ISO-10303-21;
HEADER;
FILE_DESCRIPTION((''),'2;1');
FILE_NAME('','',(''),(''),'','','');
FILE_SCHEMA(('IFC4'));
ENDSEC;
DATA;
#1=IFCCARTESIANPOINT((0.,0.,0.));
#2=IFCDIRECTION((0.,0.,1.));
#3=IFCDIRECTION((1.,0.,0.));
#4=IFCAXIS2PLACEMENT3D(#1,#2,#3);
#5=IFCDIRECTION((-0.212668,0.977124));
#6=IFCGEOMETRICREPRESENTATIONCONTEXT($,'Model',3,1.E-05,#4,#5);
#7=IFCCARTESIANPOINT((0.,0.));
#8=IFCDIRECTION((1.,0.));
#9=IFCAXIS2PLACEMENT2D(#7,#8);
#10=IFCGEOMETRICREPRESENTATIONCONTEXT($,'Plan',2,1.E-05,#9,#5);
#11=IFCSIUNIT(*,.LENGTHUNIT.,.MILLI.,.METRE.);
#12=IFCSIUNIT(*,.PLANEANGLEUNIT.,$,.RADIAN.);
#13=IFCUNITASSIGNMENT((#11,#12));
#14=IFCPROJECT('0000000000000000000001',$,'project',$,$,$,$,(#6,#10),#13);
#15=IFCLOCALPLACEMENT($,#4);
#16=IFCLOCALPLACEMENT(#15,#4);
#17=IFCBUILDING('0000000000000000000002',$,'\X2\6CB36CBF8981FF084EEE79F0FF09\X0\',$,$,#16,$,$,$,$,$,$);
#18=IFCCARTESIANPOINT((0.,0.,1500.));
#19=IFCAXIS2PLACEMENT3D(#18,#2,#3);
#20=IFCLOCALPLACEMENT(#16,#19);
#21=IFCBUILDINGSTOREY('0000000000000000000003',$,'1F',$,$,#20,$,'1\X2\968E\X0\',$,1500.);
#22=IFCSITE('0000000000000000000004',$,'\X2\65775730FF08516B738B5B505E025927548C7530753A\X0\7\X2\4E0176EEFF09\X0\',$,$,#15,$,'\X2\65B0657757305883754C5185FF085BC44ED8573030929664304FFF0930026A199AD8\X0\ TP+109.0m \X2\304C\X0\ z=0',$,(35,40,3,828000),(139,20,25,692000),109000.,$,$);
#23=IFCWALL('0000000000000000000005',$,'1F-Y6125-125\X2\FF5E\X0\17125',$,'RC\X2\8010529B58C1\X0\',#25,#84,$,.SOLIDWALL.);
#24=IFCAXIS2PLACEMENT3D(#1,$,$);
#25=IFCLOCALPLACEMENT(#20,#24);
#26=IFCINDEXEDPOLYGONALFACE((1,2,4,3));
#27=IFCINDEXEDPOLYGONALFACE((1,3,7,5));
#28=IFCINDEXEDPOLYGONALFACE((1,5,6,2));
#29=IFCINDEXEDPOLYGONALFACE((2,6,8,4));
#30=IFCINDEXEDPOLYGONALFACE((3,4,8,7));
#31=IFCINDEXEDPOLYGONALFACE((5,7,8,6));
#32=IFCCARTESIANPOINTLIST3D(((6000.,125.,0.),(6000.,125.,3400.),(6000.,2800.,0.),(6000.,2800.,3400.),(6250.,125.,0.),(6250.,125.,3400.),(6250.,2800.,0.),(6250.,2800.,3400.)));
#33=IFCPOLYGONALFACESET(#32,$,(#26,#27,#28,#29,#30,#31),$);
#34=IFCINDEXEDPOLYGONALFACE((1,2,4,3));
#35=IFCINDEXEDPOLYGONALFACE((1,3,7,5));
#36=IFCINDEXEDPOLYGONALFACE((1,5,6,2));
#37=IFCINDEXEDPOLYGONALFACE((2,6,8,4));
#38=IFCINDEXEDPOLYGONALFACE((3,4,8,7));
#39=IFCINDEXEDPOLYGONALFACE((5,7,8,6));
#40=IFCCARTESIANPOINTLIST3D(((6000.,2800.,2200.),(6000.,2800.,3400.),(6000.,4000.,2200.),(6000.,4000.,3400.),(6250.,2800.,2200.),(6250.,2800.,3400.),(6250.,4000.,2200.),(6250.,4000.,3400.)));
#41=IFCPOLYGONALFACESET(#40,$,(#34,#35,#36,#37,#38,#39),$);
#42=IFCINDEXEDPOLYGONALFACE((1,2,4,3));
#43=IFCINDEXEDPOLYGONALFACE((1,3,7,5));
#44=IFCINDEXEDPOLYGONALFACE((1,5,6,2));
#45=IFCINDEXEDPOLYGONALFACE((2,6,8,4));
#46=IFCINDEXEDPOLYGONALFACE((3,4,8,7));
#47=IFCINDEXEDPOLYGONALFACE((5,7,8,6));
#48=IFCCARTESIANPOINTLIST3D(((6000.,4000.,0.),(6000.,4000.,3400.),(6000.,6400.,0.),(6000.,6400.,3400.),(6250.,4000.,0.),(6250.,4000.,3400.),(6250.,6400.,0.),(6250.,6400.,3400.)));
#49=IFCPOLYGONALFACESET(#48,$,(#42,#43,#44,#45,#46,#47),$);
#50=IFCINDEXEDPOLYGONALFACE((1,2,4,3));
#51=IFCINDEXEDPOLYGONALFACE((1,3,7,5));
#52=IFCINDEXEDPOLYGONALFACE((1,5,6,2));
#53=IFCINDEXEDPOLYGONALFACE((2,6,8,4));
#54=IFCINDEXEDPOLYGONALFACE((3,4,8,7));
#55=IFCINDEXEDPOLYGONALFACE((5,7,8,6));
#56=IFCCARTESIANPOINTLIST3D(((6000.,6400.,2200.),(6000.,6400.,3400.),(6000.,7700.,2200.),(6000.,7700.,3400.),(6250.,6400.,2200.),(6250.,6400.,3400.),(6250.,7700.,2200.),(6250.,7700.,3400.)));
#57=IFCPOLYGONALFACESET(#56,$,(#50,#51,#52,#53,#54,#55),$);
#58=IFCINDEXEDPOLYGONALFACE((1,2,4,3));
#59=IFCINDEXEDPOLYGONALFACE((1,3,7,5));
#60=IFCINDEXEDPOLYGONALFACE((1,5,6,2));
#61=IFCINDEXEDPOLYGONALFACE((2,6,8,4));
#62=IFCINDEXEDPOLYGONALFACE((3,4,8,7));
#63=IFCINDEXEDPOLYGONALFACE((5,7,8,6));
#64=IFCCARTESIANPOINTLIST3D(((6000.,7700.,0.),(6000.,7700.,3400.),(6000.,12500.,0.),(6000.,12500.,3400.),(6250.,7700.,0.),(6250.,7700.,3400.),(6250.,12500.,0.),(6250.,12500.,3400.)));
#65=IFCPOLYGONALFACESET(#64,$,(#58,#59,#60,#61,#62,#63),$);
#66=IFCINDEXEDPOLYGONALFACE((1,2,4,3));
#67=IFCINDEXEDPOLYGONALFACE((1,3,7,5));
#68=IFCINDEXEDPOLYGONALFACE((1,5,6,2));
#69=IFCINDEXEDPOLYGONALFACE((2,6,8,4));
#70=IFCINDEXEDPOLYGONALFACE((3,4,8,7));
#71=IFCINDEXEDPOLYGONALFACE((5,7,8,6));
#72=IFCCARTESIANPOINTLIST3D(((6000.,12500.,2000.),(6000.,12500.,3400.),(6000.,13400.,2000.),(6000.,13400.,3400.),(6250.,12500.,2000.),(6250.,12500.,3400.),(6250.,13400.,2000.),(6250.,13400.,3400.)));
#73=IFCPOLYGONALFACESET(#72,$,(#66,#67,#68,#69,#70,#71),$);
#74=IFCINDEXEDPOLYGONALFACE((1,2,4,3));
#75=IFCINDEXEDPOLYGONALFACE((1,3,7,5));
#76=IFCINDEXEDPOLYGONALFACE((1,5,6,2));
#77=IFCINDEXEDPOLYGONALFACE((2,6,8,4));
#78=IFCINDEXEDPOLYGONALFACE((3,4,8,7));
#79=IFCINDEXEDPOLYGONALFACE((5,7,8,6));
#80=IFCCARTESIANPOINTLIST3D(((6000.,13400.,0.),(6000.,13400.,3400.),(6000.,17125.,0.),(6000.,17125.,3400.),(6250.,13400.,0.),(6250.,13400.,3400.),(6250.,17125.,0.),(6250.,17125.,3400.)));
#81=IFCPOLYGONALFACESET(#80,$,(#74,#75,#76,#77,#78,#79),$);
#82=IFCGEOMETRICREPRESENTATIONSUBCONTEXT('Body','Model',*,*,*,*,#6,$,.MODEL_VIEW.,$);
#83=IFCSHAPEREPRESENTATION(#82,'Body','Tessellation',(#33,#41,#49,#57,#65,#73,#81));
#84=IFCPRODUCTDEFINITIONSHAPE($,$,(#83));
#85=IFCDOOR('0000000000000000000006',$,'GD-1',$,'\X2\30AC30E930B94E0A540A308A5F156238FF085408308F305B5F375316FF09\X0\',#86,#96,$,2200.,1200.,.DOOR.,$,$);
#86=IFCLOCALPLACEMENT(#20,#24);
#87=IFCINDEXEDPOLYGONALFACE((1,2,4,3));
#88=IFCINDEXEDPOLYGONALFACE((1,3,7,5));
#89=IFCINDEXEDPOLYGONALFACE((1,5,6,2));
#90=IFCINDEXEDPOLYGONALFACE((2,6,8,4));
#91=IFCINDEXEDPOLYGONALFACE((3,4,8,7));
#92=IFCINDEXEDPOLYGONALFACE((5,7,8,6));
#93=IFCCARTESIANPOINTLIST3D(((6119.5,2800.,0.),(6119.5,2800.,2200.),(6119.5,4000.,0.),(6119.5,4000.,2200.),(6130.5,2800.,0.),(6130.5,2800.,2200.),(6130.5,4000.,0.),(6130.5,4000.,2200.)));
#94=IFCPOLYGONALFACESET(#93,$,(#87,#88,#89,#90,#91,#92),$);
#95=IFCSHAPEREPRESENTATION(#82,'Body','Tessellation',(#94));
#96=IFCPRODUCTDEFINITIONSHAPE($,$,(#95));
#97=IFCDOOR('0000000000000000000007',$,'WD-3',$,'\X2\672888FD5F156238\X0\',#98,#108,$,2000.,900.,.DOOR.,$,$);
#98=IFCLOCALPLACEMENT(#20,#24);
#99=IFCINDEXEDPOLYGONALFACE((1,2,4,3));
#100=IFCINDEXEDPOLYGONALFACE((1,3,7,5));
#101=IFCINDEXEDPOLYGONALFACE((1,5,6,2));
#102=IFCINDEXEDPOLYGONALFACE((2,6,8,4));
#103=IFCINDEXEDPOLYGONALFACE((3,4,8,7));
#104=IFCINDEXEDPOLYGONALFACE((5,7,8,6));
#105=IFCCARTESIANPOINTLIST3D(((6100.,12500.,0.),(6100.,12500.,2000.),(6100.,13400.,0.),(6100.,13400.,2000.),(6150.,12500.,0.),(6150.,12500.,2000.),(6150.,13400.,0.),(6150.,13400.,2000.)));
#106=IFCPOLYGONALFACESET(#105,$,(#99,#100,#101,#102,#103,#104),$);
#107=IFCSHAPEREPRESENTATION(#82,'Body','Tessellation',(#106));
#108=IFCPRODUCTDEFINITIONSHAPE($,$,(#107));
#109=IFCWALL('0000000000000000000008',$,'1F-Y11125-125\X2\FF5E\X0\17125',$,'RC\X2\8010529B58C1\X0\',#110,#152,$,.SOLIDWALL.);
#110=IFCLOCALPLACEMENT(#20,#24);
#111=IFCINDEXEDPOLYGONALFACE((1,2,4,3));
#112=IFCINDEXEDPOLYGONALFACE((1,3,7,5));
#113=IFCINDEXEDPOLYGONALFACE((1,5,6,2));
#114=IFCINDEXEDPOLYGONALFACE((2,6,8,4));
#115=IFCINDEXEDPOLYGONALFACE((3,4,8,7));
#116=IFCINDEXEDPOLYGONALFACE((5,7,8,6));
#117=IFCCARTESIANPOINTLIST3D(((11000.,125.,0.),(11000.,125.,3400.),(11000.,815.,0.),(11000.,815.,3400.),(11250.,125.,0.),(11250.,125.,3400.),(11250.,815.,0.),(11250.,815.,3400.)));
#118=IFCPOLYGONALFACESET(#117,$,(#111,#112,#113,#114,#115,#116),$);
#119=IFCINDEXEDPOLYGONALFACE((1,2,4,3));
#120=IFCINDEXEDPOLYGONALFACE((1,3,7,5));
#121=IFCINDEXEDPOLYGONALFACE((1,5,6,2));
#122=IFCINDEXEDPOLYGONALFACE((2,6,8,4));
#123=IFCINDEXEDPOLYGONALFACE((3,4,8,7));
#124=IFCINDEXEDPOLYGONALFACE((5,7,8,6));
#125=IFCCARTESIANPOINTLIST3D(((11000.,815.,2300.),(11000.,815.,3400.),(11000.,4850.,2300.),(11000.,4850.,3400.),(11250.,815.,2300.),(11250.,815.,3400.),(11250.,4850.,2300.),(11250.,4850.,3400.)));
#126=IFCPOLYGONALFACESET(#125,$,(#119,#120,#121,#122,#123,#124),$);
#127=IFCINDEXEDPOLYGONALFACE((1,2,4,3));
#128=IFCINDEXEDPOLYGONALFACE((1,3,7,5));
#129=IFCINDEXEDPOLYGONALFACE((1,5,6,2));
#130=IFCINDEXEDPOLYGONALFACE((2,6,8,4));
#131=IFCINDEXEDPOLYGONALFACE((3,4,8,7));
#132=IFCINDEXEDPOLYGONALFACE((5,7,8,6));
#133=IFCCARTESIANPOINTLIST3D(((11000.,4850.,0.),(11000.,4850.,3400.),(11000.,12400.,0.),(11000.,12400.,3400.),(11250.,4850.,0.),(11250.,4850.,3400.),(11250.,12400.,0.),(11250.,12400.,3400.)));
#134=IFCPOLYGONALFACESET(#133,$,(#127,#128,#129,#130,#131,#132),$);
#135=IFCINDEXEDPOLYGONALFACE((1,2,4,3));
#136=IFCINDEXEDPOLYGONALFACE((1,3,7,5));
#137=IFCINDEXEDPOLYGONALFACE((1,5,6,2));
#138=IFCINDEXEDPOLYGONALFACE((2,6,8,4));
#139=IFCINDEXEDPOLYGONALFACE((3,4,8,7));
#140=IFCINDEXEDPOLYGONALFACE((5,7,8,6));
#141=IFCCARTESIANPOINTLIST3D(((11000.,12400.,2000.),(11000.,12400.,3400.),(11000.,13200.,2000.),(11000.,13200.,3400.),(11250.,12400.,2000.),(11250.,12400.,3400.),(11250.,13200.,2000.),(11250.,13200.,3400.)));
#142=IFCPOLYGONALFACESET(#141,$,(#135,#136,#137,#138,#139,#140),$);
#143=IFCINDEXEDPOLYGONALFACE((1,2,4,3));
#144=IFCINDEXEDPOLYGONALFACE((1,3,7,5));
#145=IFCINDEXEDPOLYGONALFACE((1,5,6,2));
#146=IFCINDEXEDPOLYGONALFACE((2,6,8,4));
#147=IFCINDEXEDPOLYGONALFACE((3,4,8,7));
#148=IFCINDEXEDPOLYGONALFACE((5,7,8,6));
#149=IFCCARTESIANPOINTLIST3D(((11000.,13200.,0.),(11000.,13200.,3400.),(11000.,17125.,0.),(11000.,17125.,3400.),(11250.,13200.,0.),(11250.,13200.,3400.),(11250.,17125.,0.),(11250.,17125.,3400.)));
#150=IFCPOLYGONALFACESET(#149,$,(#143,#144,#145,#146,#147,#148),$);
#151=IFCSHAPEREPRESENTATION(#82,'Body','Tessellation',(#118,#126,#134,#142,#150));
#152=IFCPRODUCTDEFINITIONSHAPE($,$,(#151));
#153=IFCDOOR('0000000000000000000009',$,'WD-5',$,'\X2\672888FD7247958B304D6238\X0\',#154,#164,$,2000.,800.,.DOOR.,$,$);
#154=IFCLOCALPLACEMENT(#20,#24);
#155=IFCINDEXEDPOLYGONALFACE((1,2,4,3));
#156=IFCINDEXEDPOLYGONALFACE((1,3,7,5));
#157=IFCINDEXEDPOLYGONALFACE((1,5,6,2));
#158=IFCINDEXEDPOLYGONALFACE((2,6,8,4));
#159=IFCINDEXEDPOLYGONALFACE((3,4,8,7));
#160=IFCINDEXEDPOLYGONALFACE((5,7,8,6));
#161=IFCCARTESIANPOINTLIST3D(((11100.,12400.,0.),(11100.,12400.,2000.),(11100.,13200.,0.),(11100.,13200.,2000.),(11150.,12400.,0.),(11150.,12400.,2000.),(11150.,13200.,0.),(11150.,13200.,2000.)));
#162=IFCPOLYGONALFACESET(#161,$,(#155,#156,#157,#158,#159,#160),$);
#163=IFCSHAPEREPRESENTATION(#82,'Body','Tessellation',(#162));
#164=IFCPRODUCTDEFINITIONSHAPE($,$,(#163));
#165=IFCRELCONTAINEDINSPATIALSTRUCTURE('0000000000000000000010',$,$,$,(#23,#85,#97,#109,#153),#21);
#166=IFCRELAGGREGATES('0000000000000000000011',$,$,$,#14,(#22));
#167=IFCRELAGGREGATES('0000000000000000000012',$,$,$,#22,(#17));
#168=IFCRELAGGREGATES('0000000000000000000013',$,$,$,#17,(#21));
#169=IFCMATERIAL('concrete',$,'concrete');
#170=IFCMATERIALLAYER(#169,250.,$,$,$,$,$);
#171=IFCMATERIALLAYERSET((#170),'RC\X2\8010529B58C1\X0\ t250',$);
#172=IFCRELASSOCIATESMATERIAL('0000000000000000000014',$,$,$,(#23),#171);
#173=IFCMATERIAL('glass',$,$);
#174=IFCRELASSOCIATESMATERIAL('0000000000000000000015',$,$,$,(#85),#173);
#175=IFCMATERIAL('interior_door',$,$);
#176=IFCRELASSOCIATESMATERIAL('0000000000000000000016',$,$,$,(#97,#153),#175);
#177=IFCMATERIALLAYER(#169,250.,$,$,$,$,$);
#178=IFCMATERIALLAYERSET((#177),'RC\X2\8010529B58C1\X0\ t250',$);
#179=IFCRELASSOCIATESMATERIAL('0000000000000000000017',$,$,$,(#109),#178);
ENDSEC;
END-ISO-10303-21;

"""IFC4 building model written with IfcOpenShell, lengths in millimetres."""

from ifc_helpers import new_model, si_unit, direction, frame, frame_2d, origin, origin_with_axes, origin_2d_with_axis, place, context, subcontext, project, spatial, rectangle, extrude, material, layer, layer_set, layer_usage, element, fill, save


model = new_model("IFC4")

# Units and contexts
model_context = context("Model", 3, precision=1e-05, world=origin_with_axes(), true_north=direction((-0.212668, 0.977124)))
plan_context = context("Plan", 2, precision=1e-05, world=origin_2d_with_axis(), true_north=direction((-0.212668, 0.977124)))
body_context = subcontext(model_context, "Body", "Model", "MODEL_VIEW")
ifc_project = project(units=[si_unit("LENGTHUNIT", "METRE", prefix="MILLI"), si_unit("PLANEANGLEUNIT", "RADIAN")], contexts=[model_context, plan_context])

# Site, building, storey
site_placement = place(None, origin_with_axes())
site = spatial("IfcSite", under=ifc_project, at=site_placement, Name="敷地（八王子市大和田町7丁目）", LongName="新敷地境界内（寄付地を除く）。標高 TP+109.0m が z=0", RefLatitude=(35, 40, 3, 828000), RefLongitude=(139, 20, 25, 692000), RefElevation=109000.0)
building_placement = place(site_placement, origin_with_axes())
building = spatial("IfcBuilding", under=site, at=building_placement, Name="河沿要（仮称）")
storey_placement = place(building_placement, frame((0.0, 0.0, 1500.0), z_axis=(0.0, 0.0, 1.0), x_axis=(1.0, 0.0, 0.0)))
storey = spatial("IfcBuildingStorey", under=building, at=storey_placement, Name="1F", LongName="1階", Elevation=1500.0)

# Shared definitions
ifc_material_1 = material(Name="concrete", Category="concrete")
ifc_material_2 = material(Name="glass")

# Wall, openings, doors
ifc_layer_1 = layer(ifc_material_1, 250.0)
ifc_layer_set_1 = layer_set([ifc_layer_1], Name="RC耐力壁 t250")
ifc_layer_usage_1 = layer_usage(ifc_layer_set_1, "AXIS2", "POSITIVE", 0.0)
wall_1_placement = place(storey_placement, origin_with_axes())
wall_1 = element("IfcWall", 1, at=wall_1_placement, inside=storey, material=ifc_layer_usage_1, Name="1F-Y6125-125～17125", ObjectType="RC耐力壁", PredefinedType="SOLIDWALL", context=body_context, shape_type="SweptSolid", body=[
    extrude(rectangle(XDim=250.0, YDim=2675.0, at=frame_2d((6125.0, 1462.5))), origin(), (0.0, 0.0, 1.0), 3400.0),
    extrude(rectangle(XDim=250.0, YDim=1200.0, at=frame_2d((6125.0, 3400.0))), frame((0.0, 0.0, 2200.0)), (0.0, 0.0, 1.0), 1200.0),
    extrude(rectangle(XDim=250.0, YDim=2400.0, at=frame_2d((6125.0, 5200.0))), origin(), (0.0, 0.0, 1.0), 3400.0),
    extrude(rectangle(XDim=250.0, YDim=1300.0, at=frame_2d((6125.0, 7050.0))), frame((0.0, 0.0, 2200.0)), (0.0, 0.0, 1.0), 1200.0),
    extrude(rectangle(XDim=250.0, YDim=4800.0, at=frame_2d((6125.0, 10100.0))), origin(), (0.0, 0.0, 1.0), 3400.0),
    extrude(rectangle(XDim=250.0, YDim=900.0, at=frame_2d((6125.0, 12950.0))), frame((0.0, 0.0, 2000.0)), (0.0, 0.0, 1.0), 1400.0),
    extrude(rectangle(XDim=250.0, YDim=3725.0, at=frame_2d((6125.0, 15262.5))), origin(), (0.0, 0.0, 1.0), 3400.0),
])
opening_1_placement = place(storey_placement, origin_with_axes())
opening_1 = element("IfcOpeningElement", 2, at=opening_1_placement, inside=storey, cuts=wall_1, PredefinedType="OPENING", context=body_context, shape_type="SweptSolid", body=[
    extrude(rectangle(XDim=300.0, YDim=1200.0, at=frame_2d((6125.0, 3400.0))), origin(), (0.0, 0.0, 1.0), 2200.0),
])
opening_2_placement = place(storey_placement, origin_with_axes())
element("IfcOpeningElement", 3, at=opening_2_placement, inside=storey, cuts=wall_1, PredefinedType="OPENING", context=body_context, shape_type="SweptSolid", body=[
    extrude(rectangle(XDim=300.0, YDim=1300.0, at=frame_2d((6125.0, 7050.0))), origin(), (0.0, 0.0, 1.0), 2200.0),
])
opening_3_placement = place(storey_placement, origin_with_axes())
opening_3 = element("IfcOpeningElement", 4, at=opening_3_placement, inside=storey, cuts=wall_1, PredefinedType="OPENING", context=body_context, shape_type="SweptSolid", body=[
    extrude(rectangle(XDim=300.0, YDim=900.0, at=frame_2d((6125.0, 12950.0))), origin(), (0.0, 0.0, 1.0), 2000.0),
])
door_1_placement = place(storey_placement, origin_with_axes())
door_1 = element("IfcDoor", 5, at=door_1_placement, inside=storey, material=ifc_material_2, Name="GD-1", ObjectType="ガラス上吊り引戸（合わせ強化）", OverallHeight=2200.0, OverallWidth=1200.0, PredefinedType="DOOR", context=body_context, shape_type="SweptSolid", body=[
    extrude(rectangle(XDim=11.0, YDim=1200.0, at=frame_2d((6125.0, 3400.0))), origin(), (0.0, 0.0, 1.0), 2200.0),
])
fill(opening_1, door_1)
ifc_material_3 = material(Name="interior_door")
door_2_placement = place(storey_placement, origin_with_axes())
door_2 = element("IfcDoor", 6, at=door_2_placement, inside=storey, material=ifc_material_3, Name="WD-3", ObjectType="木製引戸", OverallHeight=2000.0, OverallWidth=900.0, PredefinedType="DOOR", context=body_context, shape_type="SweptSolid", body=[
    extrude(rectangle(XDim=50.0, YDim=900.0, at=frame_2d((6125.0, 12950.0))), origin(), (0.0, 0.0, 1.0), 2000.0),
])
fill(opening_3, door_2)

# Wall, openings, door
ifc_layer_2 = layer(ifc_material_1, 250.0)
ifc_layer_set_2 = layer_set([ifc_layer_2], Name="RC耐力壁 t250")
ifc_layer_usage_2 = layer_usage(ifc_layer_set_2, "AXIS2", "POSITIVE", 0.0)
wall_2_placement = place(storey_placement, origin_with_axes())
wall_2 = element("IfcWall", 7, at=wall_2_placement, inside=storey, material=ifc_layer_usage_2, Name="1F-Y11125-125～17125", ObjectType="RC耐力壁", PredefinedType="SOLIDWALL", context=body_context, shape_type="SweptSolid", body=[
    extrude(rectangle(XDim=250.0, YDim=690.0, at=frame_2d((11125.0, 470.0))), origin(), (0.0, 0.0, 1.0), 3400.0),
    extrude(rectangle(XDim=250.0, YDim=4035.0, at=frame_2d((11125.0, 2832.5))), frame((0.0, 0.0, 2300.0)), (0.0, 0.0, 1.0), 1100.0),
    extrude(rectangle(XDim=250.0, YDim=7550.0, at=frame_2d((11125.0, 8625.0))), origin(), (0.0, 0.0, 1.0), 3400.0),
    extrude(rectangle(XDim=250.0, YDim=800.0, at=frame_2d((11125.0, 12800.0))), frame((0.0, 0.0, 2000.0)), (0.0, 0.0, 1.0), 1400.0),
    extrude(rectangle(XDim=250.0, YDim=3925.0, at=frame_2d((11125.0, 15162.5))), origin(), (0.0, 0.0, 1.0), 3400.0),
])
opening_4_placement = place(storey_placement, origin_with_axes())
element("IfcOpeningElement", 8, at=opening_4_placement, inside=storey, cuts=wall_2, PredefinedType="OPENING", context=body_context, shape_type="SweptSolid", body=[
    extrude(rectangle(XDim=300.0, YDim=4035.0, at=frame_2d((11125.0, 2832.5))), origin(), (0.0, 0.0, 1.0), 2300.0),
])
opening_5_placement = place(storey_placement, origin_with_axes())
opening_5 = element("IfcOpeningElement", 9, at=opening_5_placement, inside=storey, cuts=wall_2, PredefinedType="OPENING", context=body_context, shape_type="SweptSolid", body=[
    extrude(rectangle(XDim=300.0, YDim=800.0, at=frame_2d((11125.0, 12800.0))), origin(), (0.0, 0.0, 1.0), 2000.0),
])
door_3_placement = place(storey_placement, origin_with_axes())
door_3 = element("IfcDoor", 10, at=door_3_placement, inside=storey, material=ifc_material_3, Name="WD-5", ObjectType="木製片開き戸", OverallHeight=2000.0, OverallWidth=800.0, PredefinedType="DOOR", context=body_context, shape_type="SweptSolid", body=[
    extrude(rectangle(XDim=50.0, YDim=800.0, at=frame_2d((11125.0, 12800.0))), origin(), (0.0, 0.0, 1.0), 2000.0),
])
fill(opening_5, door_3)

save(model, "model.ifc")
